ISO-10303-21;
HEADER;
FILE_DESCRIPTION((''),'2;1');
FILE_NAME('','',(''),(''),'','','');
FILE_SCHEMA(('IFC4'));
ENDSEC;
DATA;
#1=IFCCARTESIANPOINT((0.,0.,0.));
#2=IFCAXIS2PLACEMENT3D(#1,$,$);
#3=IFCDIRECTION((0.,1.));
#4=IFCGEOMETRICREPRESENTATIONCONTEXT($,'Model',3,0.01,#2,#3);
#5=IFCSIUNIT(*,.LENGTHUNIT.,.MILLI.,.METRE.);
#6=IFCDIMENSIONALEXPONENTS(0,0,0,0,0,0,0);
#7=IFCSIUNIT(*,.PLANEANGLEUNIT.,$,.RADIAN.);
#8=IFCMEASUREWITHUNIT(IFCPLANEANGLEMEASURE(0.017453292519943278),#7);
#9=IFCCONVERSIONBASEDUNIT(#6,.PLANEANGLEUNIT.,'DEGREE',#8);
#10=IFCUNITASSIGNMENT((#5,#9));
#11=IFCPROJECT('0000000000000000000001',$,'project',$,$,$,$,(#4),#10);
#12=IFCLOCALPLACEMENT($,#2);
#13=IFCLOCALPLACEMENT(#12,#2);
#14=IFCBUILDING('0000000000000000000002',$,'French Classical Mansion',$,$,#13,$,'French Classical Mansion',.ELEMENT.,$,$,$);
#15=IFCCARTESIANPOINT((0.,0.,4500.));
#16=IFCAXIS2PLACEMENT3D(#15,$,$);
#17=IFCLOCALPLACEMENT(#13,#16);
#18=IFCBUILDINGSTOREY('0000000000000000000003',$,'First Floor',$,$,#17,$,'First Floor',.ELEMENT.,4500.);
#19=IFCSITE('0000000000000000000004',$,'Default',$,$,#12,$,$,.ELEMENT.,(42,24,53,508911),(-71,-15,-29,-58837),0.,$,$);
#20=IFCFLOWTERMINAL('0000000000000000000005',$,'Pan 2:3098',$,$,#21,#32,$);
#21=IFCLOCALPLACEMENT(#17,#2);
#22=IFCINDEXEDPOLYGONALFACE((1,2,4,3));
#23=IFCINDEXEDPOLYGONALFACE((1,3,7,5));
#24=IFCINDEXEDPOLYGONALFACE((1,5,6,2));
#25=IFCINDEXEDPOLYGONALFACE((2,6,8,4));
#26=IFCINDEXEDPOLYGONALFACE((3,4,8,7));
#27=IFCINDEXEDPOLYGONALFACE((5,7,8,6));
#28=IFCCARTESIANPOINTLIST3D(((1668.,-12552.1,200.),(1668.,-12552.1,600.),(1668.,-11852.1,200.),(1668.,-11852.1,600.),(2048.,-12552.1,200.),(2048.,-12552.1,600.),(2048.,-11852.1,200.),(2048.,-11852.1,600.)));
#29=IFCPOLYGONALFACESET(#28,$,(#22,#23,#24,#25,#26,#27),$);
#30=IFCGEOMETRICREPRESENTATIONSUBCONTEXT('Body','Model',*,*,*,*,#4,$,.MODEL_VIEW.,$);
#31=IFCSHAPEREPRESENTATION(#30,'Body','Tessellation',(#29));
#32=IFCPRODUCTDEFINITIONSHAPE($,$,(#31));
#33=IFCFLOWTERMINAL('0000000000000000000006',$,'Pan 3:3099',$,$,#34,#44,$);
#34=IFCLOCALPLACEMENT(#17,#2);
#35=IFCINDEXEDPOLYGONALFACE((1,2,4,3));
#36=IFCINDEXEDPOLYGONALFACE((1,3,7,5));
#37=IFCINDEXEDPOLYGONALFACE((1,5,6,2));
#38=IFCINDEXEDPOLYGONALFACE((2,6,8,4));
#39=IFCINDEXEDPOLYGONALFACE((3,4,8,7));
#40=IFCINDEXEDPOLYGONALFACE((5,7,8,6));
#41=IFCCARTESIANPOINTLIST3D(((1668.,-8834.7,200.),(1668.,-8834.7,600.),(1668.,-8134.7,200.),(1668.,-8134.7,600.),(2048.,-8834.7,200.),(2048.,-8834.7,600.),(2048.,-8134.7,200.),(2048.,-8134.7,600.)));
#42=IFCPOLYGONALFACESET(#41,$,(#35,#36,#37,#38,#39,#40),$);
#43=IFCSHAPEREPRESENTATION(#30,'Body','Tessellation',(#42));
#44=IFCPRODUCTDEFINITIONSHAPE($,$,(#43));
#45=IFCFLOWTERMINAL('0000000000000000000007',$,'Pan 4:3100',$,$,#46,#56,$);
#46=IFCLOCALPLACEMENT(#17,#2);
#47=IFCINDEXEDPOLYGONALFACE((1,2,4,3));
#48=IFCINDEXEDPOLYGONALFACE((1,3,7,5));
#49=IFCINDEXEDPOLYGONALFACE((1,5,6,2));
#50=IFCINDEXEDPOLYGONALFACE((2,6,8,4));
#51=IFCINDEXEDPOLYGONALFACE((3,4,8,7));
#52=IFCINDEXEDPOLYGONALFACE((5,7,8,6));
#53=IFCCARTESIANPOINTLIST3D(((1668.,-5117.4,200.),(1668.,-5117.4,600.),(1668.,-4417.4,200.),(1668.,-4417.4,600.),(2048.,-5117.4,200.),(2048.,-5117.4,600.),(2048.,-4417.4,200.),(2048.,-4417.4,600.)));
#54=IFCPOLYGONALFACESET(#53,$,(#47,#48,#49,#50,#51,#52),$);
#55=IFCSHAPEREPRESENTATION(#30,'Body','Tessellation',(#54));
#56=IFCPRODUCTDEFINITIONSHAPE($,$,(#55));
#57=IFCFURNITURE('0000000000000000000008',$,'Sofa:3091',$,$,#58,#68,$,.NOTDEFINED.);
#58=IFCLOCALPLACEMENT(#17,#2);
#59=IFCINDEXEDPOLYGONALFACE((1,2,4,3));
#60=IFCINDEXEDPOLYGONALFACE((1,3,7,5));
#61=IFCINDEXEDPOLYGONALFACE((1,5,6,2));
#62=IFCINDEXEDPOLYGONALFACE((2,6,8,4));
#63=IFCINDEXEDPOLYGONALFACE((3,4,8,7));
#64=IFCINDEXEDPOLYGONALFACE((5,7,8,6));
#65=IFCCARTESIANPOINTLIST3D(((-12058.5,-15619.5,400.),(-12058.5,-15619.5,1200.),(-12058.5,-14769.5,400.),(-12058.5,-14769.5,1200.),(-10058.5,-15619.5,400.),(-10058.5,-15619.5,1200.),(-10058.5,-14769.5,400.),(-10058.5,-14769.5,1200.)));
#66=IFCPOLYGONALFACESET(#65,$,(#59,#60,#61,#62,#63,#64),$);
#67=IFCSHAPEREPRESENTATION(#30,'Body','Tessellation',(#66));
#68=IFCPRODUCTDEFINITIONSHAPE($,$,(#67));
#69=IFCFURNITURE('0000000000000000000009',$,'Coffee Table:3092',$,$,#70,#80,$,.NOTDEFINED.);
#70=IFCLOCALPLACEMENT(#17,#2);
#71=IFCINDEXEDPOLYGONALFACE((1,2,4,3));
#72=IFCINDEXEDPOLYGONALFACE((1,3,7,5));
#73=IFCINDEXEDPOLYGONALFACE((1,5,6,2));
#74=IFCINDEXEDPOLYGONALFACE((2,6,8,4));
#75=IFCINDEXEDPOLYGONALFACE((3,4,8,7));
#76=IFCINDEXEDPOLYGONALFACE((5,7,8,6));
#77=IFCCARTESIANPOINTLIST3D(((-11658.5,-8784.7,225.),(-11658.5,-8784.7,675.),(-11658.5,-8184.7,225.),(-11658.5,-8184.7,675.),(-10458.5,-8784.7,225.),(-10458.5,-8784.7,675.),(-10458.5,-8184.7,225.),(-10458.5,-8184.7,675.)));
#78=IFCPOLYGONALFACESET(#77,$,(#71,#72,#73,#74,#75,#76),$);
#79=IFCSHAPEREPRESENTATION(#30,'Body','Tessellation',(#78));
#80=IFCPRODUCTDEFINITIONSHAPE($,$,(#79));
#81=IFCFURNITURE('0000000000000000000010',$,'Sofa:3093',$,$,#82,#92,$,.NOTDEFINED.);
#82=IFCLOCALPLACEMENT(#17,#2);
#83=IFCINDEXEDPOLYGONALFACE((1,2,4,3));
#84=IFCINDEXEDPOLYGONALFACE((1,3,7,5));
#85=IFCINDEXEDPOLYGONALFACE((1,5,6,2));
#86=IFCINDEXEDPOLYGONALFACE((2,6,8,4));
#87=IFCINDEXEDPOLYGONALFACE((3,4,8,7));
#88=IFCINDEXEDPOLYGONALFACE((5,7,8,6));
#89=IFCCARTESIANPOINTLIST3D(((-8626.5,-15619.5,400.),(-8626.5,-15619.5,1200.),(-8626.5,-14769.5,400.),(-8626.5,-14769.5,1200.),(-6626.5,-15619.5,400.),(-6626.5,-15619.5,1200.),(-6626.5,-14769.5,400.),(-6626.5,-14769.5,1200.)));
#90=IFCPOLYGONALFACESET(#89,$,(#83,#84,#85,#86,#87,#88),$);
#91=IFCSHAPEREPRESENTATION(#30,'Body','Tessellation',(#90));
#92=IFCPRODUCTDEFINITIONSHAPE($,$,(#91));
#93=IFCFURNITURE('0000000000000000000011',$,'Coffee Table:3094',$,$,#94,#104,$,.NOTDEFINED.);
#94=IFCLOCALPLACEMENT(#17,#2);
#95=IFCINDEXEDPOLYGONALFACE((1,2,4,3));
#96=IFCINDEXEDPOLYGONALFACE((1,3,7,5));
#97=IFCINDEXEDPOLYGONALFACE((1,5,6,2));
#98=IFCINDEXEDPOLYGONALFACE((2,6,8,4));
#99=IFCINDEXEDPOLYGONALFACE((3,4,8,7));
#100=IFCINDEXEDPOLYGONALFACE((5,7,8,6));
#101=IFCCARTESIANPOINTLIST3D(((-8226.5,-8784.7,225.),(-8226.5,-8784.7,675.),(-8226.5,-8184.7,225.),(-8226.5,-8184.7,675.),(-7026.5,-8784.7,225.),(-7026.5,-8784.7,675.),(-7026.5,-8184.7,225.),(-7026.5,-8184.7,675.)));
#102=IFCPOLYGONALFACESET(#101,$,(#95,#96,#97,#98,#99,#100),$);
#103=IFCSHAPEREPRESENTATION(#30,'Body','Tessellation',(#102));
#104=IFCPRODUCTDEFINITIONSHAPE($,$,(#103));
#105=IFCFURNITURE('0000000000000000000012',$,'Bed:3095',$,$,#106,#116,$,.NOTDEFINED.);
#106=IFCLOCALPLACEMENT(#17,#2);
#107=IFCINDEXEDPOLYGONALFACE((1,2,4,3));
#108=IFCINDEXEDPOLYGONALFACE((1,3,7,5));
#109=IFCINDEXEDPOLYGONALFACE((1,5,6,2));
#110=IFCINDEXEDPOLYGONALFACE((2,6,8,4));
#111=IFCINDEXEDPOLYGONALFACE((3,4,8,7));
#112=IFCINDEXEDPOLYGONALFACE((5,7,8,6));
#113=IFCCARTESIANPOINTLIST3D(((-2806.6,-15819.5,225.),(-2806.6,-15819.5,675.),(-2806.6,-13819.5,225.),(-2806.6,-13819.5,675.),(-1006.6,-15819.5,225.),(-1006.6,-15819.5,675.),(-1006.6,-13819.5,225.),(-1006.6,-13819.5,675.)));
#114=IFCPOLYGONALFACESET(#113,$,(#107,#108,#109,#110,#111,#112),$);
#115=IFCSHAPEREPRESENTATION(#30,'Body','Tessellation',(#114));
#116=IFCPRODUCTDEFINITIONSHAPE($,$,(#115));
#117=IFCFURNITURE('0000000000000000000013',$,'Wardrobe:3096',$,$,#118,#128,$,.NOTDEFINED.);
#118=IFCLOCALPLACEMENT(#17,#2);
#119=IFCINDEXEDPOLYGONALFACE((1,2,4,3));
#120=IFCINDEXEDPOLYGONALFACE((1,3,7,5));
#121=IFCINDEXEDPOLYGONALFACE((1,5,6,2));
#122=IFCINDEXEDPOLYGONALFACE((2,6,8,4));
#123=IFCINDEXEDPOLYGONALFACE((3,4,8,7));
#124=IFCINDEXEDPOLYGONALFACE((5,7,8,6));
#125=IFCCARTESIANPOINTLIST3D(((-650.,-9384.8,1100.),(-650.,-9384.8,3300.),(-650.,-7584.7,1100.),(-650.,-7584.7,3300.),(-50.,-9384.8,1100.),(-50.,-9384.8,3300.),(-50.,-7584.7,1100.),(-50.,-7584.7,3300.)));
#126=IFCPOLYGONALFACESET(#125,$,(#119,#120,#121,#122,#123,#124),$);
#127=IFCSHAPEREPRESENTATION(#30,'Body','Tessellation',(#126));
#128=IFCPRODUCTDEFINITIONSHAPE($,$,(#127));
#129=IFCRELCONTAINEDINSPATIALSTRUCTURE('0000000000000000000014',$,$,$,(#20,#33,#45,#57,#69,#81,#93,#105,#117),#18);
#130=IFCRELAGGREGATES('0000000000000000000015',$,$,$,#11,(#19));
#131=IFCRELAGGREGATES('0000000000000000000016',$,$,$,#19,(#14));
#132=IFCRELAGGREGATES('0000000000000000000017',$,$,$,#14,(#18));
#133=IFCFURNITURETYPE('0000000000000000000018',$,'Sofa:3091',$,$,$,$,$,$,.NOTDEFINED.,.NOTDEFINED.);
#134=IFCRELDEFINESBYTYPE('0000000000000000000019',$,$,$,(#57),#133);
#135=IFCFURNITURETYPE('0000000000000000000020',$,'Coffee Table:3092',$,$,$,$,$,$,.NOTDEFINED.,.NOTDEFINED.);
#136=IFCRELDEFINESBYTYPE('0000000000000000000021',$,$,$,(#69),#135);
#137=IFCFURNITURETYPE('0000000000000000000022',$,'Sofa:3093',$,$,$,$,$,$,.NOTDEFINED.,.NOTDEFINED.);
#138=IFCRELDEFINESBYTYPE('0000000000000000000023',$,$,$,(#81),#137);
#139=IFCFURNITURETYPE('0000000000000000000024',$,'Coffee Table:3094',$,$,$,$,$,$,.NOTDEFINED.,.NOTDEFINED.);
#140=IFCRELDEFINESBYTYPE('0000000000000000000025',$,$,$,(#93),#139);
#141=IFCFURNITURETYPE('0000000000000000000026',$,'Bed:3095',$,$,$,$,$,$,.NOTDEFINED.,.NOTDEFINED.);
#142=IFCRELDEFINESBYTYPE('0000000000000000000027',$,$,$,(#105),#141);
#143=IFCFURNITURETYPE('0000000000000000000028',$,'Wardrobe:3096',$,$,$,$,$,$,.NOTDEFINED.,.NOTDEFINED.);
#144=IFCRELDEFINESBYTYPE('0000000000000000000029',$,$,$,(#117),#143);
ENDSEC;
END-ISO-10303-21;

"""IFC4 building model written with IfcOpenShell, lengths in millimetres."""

from ifc_helpers import new_model, entity, si_unit, converted_unit, direction, frame, frame_2d, origin, origin_2d_with_axis, place, context, subcontext, project, spatial, rectangle, extrude, type_object, element, save


model = new_model("IFC4")

# Units and contexts
model_context = context("Model", 3, precision=0.01, world=origin(), true_north=direction((0.0, 1.0)))
body_context = subcontext(model_context, "Body", "Model", "MODEL_VIEW")
ifc_project = project(units=[si_unit("LENGTHUNIT", "METRE", prefix="MILLI"), converted_unit("PLANEANGLEUNIT", "DEGREE", entity("IfcPlaneAngleMeasure", 0.017453292519943278), si_unit("PLANEANGLEUNIT", "RADIAN"), dimensions=[0, 0, 0, 0, 0, 0, 0])], contexts=[model_context])

# Site, building, storey
site_placement = place(None, origin())
site = spatial("IfcSite", under=ifc_project, at=site_placement, Name="Default", CompositionType="ELEMENT", RefLatitude=(42, 24, 53, 508911), RefLongitude=(-71, -15, -29, -58837), RefElevation=0.0)
building_placement = place(site_placement, origin())
building = spatial("IfcBuilding", under=site, at=building_placement, Name="French Classical Mansion", LongName="French Classical Mansion", CompositionType="ELEMENT")
storey_placement = place(building_placement, frame((0.0, 0.0, 4500.0)))
storey = spatial("IfcBuildingStorey", under=building, at=storey_placement, Name="First Floor", LongName="First Floor", CompositionType="ELEMENT", Elevation=4500.0)

# Flow terminals
flow_terminal_1_placement = place(storey_placement, origin())
element("IfcFlowTerminal", 1, at=flow_terminal_1_placement, inside=storey, Name="Pan 2:3098", context=body_context, shape_type="SweptSolid", body=[
    extrude(rectangle(XDim=700.0, YDim=380.0, at=origin_2d_with_axis()), frame((1858.0, -12202.1, 200.0), z_axis=(0.0, 0.0, 1.0), x_axis=(0.0, 1.0, 0.0)), (0.0, 0.0, 1.0), 400.0),
])
flow_terminal_2_placement = place(storey_placement, origin())
element("IfcFlowTerminal", 2, at=flow_terminal_2_placement, inside=storey, Name="Pan 3:3099", context=body_context, shape_type="SweptSolid", body=[
    extrude(rectangle(XDim=700.0, YDim=380.0, at=frame_2d((0.0, 0.0), x_axis=(1.0, 0.0))), frame((1858.0, -8484.7, 200.0), z_axis=(0.0, 0.0, 1.0), x_axis=(0.0, 1.0, 0.0)), (0.0, 0.0, 1.0), 400.0),
])
flow_terminal_3_placement = place(storey_placement, origin())
element("IfcFlowTerminal", 3, at=flow_terminal_3_placement, inside=storey, Name="Pan 4:3100", context=body_context, shape_type="SweptSolid", body=[
    extrude(rectangle(XDim=700.0, YDim=380.0, at=frame_2d((0.0, 0.0), x_axis=(1.0, 0.0))), frame((1858.0, -4767.4, 200.0), z_axis=(0.0, 0.0, 1.0), x_axis=(0.0, 1.0, 0.0)), (0.0, 0.0, 1.0), 400.0),
])

# Furniture
furniture_type_1 = type_object("IfcFurnitureType", Name="Sofa:3091", PredefinedType="NOTDEFINED")
furniture_1_placement = place(storey_placement, origin())
element("IfcFurniture", 4, at=furniture_1_placement, inside=storey, type_object=furniture_type_1, Name="Sofa:3091", PredefinedType="NOTDEFINED", context=body_context, shape_type="SweptSolid", body=[
    extrude(rectangle(XDim=2000.0, YDim=850.0, at=frame_2d((0.0, 0.0), x_axis=(1.0, 0.0))), frame((-11058.5, -15194.5, 400.0)), (0.0, 0.0, 1.0), 800.0),
])
furniture_type_2 = type_object("IfcFurnitureType", Name="Coffee Table:3092", PredefinedType="NOTDEFINED")
furniture_2_placement = place(storey_placement, origin())
element("IfcFurniture", 5, at=furniture_2_placement, inside=storey, type_object=furniture_type_2, Name="Coffee Table:3092", PredefinedType="NOTDEFINED", context=body_context, shape_type="SweptSolid", body=[
    extrude(rectangle(XDim=1200.0, YDim=600.0, at=frame_2d((0.0, 0.0), x_axis=(1.0, 0.0))), frame((-11058.5, -8484.7, 225.0)), (0.0, 0.0, 1.0), 450.0),
])
furniture_type_3 = type_object("IfcFurnitureType", Name="Sofa:3093", PredefinedType="NOTDEFINED")
furniture_3_placement = place(storey_placement, origin())
element("IfcFurniture", 6, at=furniture_3_placement, inside=storey, type_object=furniture_type_3, Name="Sofa:3093", PredefinedType="NOTDEFINED", context=body_context, shape_type="SweptSolid", body=[
    extrude(rectangle(XDim=2000.0, YDim=850.0, at=frame_2d((0.0, 0.0), x_axis=(1.0, 0.0))), frame((-7626.5, -15194.5, 400.0)), (0.0, 0.0, 1.0), 800.0),
])
furniture_type_4 = type_object("IfcFurnitureType", Name="Coffee Table:3094", PredefinedType="NOTDEFINED")
furniture_4_placement = place(storey_placement, origin())
element("IfcFurniture", 7, at=furniture_4_placement, inside=storey, type_object=furniture_type_4, Name="Coffee Table:3094", PredefinedType="NOTDEFINED", context=body_context, shape_type="SweptSolid", body=[
    extrude(rectangle(XDim=1200.0, YDim=600.0, at=frame_2d((0.0, 0.0), x_axis=(1.0, 0.0))), frame((-7626.5, -8484.7, 225.0)), (0.0, 0.0, 1.0), 450.0),
])
furniture_type_5 = type_object("IfcFurnitureType", Name="Bed:3095", PredefinedType="NOTDEFINED")
furniture_5_placement = place(storey_placement, origin())
element("IfcFurniture", 8, at=furniture_5_placement, inside=storey, type_object=furniture_type_5, Name="Bed:3095", PredefinedType="NOTDEFINED", context=body_context, shape_type="SweptSolid", body=[
    extrude(rectangle(XDim=1800.0, YDim=2000.0, at=origin_2d_with_axis()), frame((-1906.6, -14819.5, 225.0)), (0.0, 0.0, 1.0), 450.0),
])
furniture_type_6 = type_object("IfcFurnitureType", Name="Wardrobe:3096", PredefinedType="NOTDEFINED")
furniture_6_placement = place(storey_placement, origin())
element("IfcFurniture", 9, at=furniture_6_placement, inside=storey, type_object=furniture_type_6, Name="Wardrobe:3096", PredefinedType="NOTDEFINED", context=body_context, shape_type="SweptSolid", body=[
    extrude(rectangle(XDim=600.0, YDim=1800.0, at=origin_2d_with_axis()), frame((-350.0, -8484.8, 1100.0)), (0.0, 0.0, 1.0), 2200.0),
])

save(model, "model.ifc")
